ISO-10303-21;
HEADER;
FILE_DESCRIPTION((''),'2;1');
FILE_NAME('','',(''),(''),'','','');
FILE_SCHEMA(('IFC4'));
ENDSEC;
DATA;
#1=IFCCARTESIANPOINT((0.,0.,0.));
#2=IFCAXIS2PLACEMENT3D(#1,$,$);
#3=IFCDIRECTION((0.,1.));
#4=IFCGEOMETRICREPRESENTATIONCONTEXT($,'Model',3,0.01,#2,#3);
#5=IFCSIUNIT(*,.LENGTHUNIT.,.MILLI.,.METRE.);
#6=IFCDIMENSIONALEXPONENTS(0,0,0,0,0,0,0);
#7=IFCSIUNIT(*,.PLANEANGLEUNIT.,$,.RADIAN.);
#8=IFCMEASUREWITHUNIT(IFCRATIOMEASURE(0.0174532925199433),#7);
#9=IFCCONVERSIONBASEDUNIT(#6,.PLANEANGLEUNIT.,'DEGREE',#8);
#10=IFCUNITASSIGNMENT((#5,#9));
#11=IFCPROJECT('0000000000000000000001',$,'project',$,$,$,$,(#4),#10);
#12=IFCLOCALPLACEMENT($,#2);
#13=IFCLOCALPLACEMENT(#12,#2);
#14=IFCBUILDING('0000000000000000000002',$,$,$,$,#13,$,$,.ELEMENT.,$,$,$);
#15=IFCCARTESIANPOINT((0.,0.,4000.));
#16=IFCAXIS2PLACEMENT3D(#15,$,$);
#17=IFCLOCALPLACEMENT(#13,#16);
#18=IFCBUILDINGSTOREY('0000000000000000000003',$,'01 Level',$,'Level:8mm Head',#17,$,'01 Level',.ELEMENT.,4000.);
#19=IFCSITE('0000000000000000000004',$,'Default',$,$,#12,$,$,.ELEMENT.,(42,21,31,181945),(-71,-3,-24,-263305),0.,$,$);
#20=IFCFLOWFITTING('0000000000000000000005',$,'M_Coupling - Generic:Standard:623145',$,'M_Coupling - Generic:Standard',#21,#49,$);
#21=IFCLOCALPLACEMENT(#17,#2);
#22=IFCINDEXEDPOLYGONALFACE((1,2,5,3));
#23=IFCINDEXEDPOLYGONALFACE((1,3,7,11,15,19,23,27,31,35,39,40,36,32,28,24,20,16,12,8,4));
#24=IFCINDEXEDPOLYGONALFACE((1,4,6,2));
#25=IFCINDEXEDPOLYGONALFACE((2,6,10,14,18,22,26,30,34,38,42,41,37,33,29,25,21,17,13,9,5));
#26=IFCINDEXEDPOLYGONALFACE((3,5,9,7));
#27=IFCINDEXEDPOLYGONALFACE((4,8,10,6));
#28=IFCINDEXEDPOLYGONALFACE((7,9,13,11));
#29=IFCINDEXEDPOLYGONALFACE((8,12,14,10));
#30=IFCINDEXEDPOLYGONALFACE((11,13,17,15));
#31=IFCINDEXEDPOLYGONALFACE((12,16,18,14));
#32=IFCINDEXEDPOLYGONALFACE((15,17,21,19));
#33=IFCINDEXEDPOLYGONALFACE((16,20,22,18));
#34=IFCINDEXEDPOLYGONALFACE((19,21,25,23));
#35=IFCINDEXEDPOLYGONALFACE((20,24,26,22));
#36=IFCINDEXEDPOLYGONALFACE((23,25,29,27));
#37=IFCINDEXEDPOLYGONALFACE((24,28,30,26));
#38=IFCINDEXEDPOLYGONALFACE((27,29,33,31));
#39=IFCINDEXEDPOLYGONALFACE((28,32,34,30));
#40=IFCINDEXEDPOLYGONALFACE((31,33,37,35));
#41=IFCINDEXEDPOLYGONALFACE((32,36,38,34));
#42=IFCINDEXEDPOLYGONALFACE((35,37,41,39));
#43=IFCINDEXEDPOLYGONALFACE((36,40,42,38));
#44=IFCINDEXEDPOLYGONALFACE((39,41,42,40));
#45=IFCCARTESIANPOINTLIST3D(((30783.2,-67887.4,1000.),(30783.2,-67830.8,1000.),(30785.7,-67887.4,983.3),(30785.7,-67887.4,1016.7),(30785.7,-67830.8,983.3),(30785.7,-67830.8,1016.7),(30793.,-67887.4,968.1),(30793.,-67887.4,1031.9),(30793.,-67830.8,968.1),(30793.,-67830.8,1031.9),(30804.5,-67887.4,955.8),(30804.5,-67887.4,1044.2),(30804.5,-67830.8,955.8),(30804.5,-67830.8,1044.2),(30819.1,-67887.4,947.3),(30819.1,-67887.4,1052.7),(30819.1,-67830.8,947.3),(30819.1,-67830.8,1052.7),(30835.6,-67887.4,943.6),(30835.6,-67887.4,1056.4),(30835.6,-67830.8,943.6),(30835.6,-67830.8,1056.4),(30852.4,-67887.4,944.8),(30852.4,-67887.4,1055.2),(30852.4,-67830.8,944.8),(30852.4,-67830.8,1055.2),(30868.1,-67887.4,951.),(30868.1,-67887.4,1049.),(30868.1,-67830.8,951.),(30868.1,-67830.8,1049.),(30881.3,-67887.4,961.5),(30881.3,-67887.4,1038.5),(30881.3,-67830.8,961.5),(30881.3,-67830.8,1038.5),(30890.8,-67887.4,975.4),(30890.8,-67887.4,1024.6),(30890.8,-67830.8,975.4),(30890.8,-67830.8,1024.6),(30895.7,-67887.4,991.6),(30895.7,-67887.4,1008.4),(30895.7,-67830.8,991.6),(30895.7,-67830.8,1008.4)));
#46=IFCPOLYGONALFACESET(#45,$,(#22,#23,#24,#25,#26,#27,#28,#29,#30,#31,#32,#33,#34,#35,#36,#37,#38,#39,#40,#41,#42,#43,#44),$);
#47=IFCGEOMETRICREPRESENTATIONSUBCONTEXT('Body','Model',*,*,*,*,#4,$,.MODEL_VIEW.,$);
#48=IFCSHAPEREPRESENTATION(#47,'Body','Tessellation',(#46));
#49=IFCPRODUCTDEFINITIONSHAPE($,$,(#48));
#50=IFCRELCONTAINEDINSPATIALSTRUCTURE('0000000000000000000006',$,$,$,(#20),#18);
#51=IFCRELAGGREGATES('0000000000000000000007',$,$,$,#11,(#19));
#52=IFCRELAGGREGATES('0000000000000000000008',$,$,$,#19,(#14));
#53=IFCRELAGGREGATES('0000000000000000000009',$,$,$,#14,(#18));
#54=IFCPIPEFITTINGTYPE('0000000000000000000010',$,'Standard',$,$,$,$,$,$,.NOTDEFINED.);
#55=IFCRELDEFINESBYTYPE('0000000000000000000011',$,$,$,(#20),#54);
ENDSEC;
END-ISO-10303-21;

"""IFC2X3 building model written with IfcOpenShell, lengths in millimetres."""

from ifc_helpers import new_model, entity, si_unit, converted_unit, direction, frame, frame_2d, origin, place, context, subcontext, project, spatial, circle, extrude, source, transform, mapped, type_object, type_shapes, element, save


model = new_model("IFC2X3")

# Units and contexts
model_context = context("Model", 3, precision=0.01, world=origin(), true_north=direction((0.0, 1.0)))
body_context = subcontext(model_context, "Body", "Model", "MODEL_VIEW")
ifc_project = project(units=[si_unit("LENGTHUNIT", "METRE", prefix="MILLI"), converted_unit("PLANEANGLEUNIT", "DEGREE", entity("IfcRatioMeasure", 0.0174532925199433), si_unit("PLANEANGLEUNIT", "RADIAN"), dimensions=[0, 0, 0, 0, 0, 0, 0])], contexts=[model_context])

# Site, building, storey
site_placement = place(None, origin())
site = spatial("IfcSite", under=ifc_project, at=site_placement, Name="Default", CompositionType="ELEMENT", RefLatitude=(42, 21, 31, 181945), RefLongitude=(-71, -3, -24, -263305), RefElevation=0.0)
building_placement = place(site_placement, origin())
building = spatial("IfcBuilding", under=site, at=building_placement, CompositionType="ELEMENT")
storey_placement = place(building_placement, frame((0.0, 0.0, 4000.0)))
storey = spatial("IfcBuildingStorey", under=building, at=storey_placement, Name="01 Level", ObjectType="Level:8mm Head", LongName="01 Level", CompositionType="ELEMENT", Elevation=4000.0)

# Flow fitting
pipe_fitting_type = type_object("IfcPipeFittingType", Name="Standard", PredefinedType="NOTDEFINED")
shared_shape = source(origin(), body_context, "Body", "SweptSolid", [
    extrude(circle(Radius=56.6, at=frame_2d((0.0, 0.0), x_axis=(1.0, 0.0))), frame((-28.3, 0.0, 0.0), z_axis=(1.0, 0.0, 0.0), x_axis=(0.0, 1.0, 0.0)), (0.0, 0.0, 1.0), 56.6),
])
type_shapes(pipe_fitting_type, [shared_shape])
flow_fitting_placement = place(storey_placement, frame((30839.8, -67859.1, 1000.0), z_axis=(0.0, 0.0, 1.0), x_axis=(0.0, 1.0, 0.0)))
element("IfcFlowFitting", 1, at=flow_fitting_placement, inside=storey, type_object=pipe_fitting_type, Name="M_Coupling - Generic:Standard:623145", ObjectType="M_Coupling - Generic:Standard", context=body_context, shape_type="MappedRepresentation", body=[
    mapped(shared_shape, transform((0.0, 0.0, 0.0), scale=1.0)),
])

save(model, "model.ifc")
